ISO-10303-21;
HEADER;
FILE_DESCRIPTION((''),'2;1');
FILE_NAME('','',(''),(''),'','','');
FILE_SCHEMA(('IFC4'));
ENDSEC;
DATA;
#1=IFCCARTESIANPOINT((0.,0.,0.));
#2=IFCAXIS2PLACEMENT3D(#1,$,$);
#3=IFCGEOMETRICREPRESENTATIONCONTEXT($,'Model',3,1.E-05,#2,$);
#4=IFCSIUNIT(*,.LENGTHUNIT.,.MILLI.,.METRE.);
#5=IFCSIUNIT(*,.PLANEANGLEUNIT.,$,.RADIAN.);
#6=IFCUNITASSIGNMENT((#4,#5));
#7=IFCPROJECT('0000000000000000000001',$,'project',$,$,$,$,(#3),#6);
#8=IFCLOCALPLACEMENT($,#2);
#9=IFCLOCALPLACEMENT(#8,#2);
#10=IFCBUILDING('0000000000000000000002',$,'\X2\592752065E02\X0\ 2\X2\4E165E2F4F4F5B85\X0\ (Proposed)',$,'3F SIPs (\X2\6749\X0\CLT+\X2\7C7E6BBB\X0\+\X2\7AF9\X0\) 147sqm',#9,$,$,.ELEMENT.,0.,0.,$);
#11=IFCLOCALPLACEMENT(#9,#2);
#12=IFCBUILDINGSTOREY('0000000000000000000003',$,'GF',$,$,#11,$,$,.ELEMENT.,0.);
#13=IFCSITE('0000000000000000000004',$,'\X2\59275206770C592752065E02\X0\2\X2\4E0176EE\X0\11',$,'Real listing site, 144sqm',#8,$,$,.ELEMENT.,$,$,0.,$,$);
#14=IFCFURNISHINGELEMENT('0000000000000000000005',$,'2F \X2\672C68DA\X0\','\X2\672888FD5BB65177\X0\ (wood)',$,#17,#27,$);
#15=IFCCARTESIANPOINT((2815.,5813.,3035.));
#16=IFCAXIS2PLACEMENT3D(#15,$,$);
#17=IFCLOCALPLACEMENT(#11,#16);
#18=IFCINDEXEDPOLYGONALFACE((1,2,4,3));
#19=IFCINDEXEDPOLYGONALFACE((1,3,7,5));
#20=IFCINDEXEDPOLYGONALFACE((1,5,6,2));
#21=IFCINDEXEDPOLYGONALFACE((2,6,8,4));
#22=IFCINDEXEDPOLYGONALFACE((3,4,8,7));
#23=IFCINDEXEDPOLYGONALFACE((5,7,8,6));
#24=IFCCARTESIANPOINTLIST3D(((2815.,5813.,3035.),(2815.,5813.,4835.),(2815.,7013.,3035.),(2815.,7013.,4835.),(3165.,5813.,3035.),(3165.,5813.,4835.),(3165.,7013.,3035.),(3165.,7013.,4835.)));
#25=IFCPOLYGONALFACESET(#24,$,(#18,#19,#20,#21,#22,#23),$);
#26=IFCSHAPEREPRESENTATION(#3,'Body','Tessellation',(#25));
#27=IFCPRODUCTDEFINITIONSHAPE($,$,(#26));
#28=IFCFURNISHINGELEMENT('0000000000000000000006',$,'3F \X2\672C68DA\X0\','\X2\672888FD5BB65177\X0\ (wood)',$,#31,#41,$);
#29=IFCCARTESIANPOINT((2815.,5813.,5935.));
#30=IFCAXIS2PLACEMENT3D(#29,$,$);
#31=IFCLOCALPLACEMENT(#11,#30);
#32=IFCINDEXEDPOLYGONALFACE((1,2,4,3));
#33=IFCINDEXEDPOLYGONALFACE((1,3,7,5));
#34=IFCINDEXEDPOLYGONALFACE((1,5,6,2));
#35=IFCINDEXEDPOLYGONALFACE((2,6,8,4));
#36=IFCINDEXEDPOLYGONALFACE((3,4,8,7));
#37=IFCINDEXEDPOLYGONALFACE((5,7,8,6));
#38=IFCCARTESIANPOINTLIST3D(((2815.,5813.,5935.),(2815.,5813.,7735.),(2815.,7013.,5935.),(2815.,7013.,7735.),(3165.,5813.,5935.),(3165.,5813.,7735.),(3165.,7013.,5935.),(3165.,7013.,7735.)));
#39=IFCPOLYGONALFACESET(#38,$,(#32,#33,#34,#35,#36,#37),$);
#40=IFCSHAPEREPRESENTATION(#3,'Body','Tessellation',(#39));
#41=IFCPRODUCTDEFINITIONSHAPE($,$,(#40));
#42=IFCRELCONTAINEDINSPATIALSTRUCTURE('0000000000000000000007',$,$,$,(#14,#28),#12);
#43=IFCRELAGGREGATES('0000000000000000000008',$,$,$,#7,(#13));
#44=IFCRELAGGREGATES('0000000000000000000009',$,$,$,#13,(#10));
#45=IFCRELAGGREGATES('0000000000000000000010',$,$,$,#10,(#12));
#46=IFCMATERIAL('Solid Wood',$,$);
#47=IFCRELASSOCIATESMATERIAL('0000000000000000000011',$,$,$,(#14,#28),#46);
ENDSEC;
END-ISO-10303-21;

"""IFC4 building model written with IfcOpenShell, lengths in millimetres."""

from ifc_helpers import new_model, si_unit, frame, frame_2d, origin, place, context, project, spatial, rectangle, extrude, material, element, save


model = new_model("IFC4")

# Units and contexts
model_context = context("Model", 3, precision=1e-05, world=origin())
ifc_project = project(units=[si_unit("LENGTHUNIT", "METRE", prefix="MILLI"), si_unit("PLANEANGLEUNIT", "RADIAN")], contexts=[model_context])

# Site, building, storey
site_placement = place(None, origin())
site = spatial("IfcSite", under=ifc_project, at=site_placement, Name="大分県大分市2丁目11", ObjectType="Real listing site, 144sqm", CompositionType="ELEMENT", RefElevation=0.0)
building_placement = place(site_placement, origin())
building = spatial("IfcBuilding", under=site, at=building_placement, Name="大分市 2世帯住宅 (Proposed)", ObjectType="3F SIPs (杉CLT+籾殻+竹) 147sqm", CompositionType="ELEMENT", ElevationOfRefHeight=0.0, ElevationOfTerrain=0.0)
storey_placement = place(building_placement, origin())
storey = spatial("IfcBuildingStorey", under=building, at=storey_placement, Name="GF", CompositionType="ELEMENT", Elevation=0.0)

# Shared definitions
ifc_material_1 = material(Name="Solid Wood")

# Furnishing elements
furnishing_1_placement = place(storey_placement, frame((2815.0, 5813.0, 3035.0)))
element("IfcFurnishingElement", 1, at=furnishing_1_placement, inside=storey, material=ifc_material_1, Name="2F 本棚", Description="木製家具 (wood)", context=model_context, shape_type="SweptSolid", body=[
    extrude(rectangle(XDim=350.0, YDim=1200.0, at=frame_2d((175.0, 600.0))), frame((2815.0, 5813.0, 3035.0)), (0.0, 0.0, 1.0), 1800.0),
])
furnishing_2_placement = place(storey_placement, frame((2815.0, 5813.0, 5935.0)))
element("IfcFurnishingElement", 2, at=furnishing_2_placement, inside=storey, material=ifc_material_1, Name="3F 本棚", Description="木製家具 (wood)", context=model_context, shape_type="SweptSolid", body=[
    extrude(rectangle(XDim=350.0, YDim=1200.0, at=frame_2d((175.0, 600.0))), frame((2815.0, 5813.0, 5935.0)), (0.0, 0.0, 1.0), 1800.0),
])

save(model, "model.ifc")
